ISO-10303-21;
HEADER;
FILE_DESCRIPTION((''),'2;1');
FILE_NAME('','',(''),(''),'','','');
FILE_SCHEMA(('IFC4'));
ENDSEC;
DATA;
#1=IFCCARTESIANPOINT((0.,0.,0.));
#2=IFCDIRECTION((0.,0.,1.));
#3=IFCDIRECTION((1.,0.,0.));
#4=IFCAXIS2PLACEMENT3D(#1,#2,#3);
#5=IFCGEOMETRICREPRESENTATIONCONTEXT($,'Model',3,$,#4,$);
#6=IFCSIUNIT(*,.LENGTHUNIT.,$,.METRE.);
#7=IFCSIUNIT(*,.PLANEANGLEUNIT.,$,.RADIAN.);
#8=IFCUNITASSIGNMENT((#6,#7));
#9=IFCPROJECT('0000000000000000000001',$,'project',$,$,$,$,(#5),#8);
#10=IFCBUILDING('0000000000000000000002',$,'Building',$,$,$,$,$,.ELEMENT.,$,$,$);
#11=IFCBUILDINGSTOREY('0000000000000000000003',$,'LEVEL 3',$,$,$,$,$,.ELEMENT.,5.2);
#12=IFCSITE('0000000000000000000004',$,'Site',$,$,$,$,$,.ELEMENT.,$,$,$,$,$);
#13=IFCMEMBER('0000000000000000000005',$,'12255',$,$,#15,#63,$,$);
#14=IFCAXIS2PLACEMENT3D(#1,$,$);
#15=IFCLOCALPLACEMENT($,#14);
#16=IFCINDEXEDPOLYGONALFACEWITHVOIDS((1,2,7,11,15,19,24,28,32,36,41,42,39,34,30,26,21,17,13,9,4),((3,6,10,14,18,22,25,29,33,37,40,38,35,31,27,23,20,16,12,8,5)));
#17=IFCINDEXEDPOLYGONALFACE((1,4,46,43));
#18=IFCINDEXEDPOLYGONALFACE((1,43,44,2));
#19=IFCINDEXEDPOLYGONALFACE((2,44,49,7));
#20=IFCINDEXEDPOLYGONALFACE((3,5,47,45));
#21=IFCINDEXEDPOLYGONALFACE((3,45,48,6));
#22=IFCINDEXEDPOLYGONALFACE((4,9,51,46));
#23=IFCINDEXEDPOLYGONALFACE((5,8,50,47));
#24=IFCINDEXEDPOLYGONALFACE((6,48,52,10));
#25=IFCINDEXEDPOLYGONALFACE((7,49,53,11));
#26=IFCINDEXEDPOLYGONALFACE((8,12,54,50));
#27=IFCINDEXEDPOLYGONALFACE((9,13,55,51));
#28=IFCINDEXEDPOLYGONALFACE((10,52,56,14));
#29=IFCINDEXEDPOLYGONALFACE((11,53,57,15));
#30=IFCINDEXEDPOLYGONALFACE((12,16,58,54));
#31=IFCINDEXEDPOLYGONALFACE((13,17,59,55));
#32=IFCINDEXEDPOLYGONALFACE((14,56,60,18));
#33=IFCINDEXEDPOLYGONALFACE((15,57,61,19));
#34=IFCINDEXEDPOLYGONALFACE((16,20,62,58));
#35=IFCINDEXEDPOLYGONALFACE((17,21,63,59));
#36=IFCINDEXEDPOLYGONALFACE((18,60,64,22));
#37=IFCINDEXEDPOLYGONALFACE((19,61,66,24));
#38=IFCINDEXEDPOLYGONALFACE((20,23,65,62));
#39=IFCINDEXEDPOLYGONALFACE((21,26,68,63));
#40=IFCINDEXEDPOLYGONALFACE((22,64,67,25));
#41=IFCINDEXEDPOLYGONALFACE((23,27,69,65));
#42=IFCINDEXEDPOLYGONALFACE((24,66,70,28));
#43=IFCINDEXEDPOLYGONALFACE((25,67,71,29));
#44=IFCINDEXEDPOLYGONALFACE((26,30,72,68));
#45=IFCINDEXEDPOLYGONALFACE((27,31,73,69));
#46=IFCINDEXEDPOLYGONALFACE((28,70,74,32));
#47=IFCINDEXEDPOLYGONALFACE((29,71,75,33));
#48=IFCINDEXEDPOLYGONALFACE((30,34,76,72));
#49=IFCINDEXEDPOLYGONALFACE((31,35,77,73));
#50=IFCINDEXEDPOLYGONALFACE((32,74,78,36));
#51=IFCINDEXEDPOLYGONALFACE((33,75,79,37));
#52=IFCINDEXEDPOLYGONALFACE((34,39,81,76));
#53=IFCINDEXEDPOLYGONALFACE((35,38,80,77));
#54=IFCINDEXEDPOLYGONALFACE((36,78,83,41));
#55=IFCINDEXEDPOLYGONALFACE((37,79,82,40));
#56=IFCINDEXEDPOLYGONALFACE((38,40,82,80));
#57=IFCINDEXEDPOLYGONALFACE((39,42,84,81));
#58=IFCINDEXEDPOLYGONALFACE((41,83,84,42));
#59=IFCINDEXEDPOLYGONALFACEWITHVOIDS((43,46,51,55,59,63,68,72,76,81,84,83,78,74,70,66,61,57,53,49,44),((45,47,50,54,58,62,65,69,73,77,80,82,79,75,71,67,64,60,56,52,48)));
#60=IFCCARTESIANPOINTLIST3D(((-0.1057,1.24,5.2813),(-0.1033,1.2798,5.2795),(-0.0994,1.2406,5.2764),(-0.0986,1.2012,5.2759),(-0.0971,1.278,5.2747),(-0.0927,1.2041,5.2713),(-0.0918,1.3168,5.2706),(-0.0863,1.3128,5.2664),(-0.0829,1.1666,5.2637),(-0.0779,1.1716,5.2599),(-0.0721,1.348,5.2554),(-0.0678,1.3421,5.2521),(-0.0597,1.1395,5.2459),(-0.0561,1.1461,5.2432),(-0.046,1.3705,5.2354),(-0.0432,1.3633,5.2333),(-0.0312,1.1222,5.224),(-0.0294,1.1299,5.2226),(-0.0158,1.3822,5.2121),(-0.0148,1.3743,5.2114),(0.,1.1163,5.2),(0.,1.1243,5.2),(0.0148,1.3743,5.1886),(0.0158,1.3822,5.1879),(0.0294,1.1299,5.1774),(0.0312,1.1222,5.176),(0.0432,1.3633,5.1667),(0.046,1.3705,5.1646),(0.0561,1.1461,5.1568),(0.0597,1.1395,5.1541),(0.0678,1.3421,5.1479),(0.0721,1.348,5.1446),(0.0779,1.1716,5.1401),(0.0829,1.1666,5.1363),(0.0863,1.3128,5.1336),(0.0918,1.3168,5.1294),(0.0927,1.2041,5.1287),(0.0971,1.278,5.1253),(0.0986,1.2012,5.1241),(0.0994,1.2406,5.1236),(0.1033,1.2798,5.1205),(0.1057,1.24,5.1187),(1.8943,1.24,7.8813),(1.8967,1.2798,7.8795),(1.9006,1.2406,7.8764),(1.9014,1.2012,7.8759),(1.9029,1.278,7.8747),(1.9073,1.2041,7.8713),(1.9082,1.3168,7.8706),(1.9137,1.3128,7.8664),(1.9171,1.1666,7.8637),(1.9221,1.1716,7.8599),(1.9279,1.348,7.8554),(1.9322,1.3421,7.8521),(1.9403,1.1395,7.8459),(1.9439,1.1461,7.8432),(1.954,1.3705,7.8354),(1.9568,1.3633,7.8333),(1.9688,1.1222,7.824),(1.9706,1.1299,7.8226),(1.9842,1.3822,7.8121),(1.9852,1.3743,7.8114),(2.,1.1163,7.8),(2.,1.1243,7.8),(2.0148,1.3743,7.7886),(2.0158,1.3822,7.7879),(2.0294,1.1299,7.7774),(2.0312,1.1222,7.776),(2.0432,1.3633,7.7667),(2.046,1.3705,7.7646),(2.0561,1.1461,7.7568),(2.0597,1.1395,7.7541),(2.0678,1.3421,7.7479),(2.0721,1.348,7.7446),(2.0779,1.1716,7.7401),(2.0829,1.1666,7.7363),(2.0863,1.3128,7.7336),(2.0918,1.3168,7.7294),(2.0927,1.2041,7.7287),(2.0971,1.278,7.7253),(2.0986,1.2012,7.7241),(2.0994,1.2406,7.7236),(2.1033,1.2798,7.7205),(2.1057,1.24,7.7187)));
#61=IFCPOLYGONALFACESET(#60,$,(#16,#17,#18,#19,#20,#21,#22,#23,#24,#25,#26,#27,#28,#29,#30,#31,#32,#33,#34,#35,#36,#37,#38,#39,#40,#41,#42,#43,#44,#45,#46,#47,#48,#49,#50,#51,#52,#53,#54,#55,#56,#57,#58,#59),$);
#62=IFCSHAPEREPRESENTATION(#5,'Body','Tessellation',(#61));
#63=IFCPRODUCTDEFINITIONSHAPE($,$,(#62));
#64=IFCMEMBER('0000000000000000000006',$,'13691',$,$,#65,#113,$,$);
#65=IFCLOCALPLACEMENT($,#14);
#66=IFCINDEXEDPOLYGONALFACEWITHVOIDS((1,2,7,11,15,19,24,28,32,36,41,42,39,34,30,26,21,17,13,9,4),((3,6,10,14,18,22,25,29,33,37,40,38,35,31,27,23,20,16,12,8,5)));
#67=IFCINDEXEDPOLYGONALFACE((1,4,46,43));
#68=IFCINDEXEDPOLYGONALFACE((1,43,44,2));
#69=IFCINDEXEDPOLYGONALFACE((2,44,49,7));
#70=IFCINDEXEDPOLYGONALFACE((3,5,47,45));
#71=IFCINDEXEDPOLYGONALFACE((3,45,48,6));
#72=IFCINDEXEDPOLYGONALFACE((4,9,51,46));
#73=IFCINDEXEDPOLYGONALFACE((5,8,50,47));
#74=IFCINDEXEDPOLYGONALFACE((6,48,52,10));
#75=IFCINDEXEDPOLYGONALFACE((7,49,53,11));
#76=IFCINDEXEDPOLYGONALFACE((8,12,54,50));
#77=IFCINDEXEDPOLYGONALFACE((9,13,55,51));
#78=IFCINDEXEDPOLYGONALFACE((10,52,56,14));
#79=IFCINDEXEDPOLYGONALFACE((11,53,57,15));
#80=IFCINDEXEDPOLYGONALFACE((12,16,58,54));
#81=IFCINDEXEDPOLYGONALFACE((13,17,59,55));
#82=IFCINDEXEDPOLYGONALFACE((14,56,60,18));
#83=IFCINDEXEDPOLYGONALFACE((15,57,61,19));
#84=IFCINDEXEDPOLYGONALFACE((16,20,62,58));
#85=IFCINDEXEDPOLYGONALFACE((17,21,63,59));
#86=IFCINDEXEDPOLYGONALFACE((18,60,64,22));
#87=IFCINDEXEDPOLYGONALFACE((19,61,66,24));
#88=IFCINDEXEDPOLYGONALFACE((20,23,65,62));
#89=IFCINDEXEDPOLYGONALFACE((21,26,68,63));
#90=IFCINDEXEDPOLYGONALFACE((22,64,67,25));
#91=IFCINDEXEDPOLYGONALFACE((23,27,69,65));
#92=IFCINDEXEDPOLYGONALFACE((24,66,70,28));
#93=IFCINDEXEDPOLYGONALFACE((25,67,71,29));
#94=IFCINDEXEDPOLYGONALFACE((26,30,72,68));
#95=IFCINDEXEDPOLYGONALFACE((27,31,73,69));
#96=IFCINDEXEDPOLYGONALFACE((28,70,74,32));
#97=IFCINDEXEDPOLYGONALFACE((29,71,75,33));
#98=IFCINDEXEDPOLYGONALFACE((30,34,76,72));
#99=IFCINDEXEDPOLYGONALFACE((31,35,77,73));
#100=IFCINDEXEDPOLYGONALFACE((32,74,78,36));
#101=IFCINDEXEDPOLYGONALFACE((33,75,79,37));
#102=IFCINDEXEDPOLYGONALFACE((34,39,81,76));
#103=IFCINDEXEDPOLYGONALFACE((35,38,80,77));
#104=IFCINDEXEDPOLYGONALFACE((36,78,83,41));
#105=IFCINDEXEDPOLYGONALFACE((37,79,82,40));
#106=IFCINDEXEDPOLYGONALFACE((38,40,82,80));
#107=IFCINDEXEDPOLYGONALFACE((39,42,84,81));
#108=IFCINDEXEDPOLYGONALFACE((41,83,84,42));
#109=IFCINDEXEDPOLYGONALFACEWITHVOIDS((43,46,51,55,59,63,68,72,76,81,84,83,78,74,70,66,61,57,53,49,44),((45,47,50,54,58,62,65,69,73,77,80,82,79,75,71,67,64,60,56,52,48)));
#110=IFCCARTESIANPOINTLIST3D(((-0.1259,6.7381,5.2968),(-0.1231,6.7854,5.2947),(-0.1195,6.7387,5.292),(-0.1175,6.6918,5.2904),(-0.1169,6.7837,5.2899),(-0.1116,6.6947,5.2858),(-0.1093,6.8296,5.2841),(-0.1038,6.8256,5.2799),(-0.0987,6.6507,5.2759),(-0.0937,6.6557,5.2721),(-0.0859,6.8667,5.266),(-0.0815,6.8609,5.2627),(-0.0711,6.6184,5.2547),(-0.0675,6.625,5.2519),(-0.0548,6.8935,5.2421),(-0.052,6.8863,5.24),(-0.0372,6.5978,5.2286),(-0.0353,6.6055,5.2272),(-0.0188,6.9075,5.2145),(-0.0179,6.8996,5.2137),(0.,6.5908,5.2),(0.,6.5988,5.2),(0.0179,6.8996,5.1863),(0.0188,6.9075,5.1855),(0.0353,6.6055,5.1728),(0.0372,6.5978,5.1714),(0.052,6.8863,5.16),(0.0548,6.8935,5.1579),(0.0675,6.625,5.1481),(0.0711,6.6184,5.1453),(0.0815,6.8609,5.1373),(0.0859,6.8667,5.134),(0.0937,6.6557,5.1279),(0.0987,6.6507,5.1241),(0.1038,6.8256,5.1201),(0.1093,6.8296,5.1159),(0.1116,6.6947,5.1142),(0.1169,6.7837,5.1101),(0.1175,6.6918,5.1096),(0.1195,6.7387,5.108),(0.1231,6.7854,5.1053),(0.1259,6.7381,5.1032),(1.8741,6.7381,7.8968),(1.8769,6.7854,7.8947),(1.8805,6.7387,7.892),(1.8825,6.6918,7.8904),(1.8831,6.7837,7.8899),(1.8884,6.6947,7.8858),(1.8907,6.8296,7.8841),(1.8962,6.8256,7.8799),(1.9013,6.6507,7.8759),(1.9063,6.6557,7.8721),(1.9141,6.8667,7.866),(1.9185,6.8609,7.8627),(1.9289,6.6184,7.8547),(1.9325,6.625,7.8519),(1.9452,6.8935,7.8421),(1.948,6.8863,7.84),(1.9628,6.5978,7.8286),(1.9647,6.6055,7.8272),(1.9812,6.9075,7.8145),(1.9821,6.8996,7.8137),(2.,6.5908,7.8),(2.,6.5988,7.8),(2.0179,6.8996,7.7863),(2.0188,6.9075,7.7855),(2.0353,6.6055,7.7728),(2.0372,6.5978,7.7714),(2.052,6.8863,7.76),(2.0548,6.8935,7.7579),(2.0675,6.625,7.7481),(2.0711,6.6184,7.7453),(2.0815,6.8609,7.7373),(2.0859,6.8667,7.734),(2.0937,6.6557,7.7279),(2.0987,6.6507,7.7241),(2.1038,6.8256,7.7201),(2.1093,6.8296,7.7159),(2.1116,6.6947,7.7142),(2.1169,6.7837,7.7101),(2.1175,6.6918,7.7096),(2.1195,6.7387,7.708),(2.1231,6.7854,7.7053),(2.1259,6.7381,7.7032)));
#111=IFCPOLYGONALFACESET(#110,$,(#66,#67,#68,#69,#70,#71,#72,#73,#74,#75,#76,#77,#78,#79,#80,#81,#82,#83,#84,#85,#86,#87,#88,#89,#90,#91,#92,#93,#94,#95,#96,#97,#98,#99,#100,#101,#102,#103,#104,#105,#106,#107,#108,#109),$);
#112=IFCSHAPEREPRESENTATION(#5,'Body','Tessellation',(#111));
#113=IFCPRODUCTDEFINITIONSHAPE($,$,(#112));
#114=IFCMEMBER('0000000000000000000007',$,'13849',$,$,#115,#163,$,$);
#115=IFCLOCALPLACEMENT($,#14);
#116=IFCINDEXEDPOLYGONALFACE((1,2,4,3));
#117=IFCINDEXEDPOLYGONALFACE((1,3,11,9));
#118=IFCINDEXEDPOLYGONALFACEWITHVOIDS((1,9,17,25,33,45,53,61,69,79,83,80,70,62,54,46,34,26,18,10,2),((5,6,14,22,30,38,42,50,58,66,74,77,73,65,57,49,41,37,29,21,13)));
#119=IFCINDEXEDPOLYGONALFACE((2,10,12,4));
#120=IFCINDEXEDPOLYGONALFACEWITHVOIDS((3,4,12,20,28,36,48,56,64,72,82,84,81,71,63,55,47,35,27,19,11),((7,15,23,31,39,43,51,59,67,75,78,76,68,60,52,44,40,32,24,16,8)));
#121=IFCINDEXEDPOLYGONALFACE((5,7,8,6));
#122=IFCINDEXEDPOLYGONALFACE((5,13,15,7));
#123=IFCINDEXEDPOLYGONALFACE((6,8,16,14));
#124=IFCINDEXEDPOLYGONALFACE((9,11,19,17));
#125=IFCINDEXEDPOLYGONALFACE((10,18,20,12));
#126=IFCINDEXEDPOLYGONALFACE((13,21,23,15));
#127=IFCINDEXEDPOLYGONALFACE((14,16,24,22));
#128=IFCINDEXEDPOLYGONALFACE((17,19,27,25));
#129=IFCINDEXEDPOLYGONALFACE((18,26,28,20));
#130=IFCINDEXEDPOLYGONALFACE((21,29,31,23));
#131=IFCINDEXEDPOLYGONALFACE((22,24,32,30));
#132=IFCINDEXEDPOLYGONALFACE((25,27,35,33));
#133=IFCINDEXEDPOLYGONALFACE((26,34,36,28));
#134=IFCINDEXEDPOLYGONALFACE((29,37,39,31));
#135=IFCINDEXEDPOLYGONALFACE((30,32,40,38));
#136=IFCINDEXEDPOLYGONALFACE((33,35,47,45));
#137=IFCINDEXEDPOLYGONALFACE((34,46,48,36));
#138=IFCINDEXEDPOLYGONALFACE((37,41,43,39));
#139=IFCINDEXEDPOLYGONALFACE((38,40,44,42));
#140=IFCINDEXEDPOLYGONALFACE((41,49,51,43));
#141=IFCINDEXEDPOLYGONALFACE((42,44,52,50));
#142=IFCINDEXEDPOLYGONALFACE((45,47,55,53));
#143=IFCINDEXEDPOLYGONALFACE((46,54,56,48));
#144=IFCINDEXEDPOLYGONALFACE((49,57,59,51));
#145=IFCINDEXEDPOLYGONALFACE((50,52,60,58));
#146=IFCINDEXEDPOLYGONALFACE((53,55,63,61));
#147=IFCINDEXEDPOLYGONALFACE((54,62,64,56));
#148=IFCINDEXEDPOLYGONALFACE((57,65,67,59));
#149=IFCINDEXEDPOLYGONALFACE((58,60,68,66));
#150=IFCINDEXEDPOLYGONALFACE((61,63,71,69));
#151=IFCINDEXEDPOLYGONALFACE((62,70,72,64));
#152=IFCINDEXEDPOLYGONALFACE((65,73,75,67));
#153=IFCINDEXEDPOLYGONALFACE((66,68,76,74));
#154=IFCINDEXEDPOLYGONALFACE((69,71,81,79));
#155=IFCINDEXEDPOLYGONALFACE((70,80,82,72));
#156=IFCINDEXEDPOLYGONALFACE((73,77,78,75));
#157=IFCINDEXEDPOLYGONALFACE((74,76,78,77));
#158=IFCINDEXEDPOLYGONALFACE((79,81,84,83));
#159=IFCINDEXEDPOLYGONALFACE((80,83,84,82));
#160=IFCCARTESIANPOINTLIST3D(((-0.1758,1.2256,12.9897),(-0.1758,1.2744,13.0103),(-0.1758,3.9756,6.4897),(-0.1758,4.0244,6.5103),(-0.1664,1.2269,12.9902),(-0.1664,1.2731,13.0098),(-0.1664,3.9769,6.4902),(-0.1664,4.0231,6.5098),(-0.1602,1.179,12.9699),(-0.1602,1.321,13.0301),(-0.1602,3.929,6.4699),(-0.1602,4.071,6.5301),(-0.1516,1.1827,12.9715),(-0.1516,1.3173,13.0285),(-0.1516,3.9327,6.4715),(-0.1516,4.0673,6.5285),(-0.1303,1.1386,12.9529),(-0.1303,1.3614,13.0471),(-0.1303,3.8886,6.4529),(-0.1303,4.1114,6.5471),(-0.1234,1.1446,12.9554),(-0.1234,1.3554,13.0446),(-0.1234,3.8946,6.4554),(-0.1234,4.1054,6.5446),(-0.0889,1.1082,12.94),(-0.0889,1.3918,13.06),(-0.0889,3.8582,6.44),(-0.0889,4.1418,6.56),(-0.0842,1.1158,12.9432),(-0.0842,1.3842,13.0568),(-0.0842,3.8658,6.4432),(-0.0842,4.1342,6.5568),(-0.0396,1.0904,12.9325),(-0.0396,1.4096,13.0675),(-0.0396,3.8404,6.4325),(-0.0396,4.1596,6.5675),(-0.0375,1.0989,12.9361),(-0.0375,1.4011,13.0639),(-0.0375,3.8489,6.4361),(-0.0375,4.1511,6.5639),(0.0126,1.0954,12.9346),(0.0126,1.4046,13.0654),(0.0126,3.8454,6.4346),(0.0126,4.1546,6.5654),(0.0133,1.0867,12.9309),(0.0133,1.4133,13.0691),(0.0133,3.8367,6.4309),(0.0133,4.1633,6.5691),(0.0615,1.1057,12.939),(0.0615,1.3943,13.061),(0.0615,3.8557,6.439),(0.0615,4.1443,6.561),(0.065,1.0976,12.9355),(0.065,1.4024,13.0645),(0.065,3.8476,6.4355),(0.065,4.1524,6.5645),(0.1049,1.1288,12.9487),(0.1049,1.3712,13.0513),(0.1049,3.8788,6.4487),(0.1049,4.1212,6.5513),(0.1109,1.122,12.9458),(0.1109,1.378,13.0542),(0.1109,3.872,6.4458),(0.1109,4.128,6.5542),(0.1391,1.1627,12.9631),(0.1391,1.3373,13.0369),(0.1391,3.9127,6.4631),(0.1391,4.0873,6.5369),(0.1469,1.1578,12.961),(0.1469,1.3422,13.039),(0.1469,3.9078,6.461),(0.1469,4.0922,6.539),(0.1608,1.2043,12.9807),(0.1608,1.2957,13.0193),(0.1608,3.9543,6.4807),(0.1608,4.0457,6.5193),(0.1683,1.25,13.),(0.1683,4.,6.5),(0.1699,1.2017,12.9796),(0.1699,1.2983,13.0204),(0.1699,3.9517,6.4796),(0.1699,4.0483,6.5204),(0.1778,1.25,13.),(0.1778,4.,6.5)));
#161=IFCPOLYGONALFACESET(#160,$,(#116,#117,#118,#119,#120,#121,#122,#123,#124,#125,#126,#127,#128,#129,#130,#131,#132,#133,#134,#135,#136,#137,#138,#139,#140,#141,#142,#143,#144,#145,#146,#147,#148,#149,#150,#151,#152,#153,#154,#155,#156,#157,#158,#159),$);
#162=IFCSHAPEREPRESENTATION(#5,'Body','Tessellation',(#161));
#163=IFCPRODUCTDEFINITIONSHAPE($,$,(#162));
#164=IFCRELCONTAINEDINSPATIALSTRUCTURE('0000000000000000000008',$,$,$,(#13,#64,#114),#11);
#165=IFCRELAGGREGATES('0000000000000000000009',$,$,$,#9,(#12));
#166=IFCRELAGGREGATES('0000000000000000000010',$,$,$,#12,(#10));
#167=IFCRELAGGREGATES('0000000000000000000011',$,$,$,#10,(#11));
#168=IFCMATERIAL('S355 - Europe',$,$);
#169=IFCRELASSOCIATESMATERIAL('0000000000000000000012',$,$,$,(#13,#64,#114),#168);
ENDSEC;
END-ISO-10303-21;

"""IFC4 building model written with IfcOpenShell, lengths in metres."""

from ifc_helpers import new_model, si_unit, frame, origin_with_axes, origin_2d_with_axis, place, context, project, spatial, hollow_circle, extrude, material, material_profile, profile_set, profile_usage, element, save


model = new_model("IFC4")

# Units and contexts
model_context = context("Model", 3, world=origin_with_axes())
ifc_project = project(units=[si_unit("LENGTHUNIT", "METRE"), si_unit("PLANEANGLEUNIT", "RADIAN")], contexts=[model_context])

# Site, building, storey
site = spatial("IfcSite", under=ifc_project, Name="Site", CompositionType="ELEMENT")
building = spatial("IfcBuilding", under=site, Name="Building", CompositionType="ELEMENT")
storey = spatial("IfcBuildingStorey", under=building, Name="LEVEL 3", CompositionType="ELEMENT", Elevation=5.2)

# Shared definitions
ifc_material = material(Name="S355 - Europe")

# Members
ifc_material_profile_1 = material_profile(ifc_material, hollow_circle(Radius=0.1337, WallThickness=0.008, at=origin_2d_with_axis()))
ifc_profile_set_1 = profile_set([ifc_material_profile_1])
ifc_profile_usage_1 = profile_usage(ifc_profile_set_1, cardinal=10)
member_1_placement = place(None, frame((2.0, 1.25, 7.8), z_axis=(-0.609711, 0.0, -0.792624), x_axis=(0.0, -1.0, 0.0)))
element("IfcMember", 1, at=member_1_placement, inside=storey, material=ifc_profile_usage_1, Name="12255", context=model_context, shape_type="SweptSolid", body=[
    extrude(hollow_circle(Radius=0.1337, WallThickness=0.008, at=origin_2d_with_axis()), origin_with_axes(), (0.0, 0.0, 1.0), 3.2802),
])
ifc_material_profile_2 = material_profile(ifc_material, hollow_circle(Radius=0.1593, WallThickness=0.008, at=origin_2d_with_axis()))
ifc_profile_set_2 = profile_set([ifc_material_profile_2])
ifc_profile_usage_2 = profile_usage(ifc_profile_set_2, cardinal=10)
member_2_placement = place(None, frame((2.0, 6.75, 7.8), z_axis=(-0.609711, 0.0, -0.792624), x_axis=(0.0, -1.0, 0.0)))
element("IfcMember", 2, at=member_2_placement, inside=storey, material=ifc_profile_usage_2, Name="13691", context=model_context, shape_type="SweptSolid", body=[
    extrude(hollow_circle(Radius=0.1593, WallThickness=0.008, at=origin_2d_with_axis()), origin_with_axes(), (0.0, 0.0, 1.0), 3.2802),
])
ifc_material_profile_3 = material_profile(ifc_material, hollow_circle(Radius=0.1778, WallThickness=0.0095, at=origin_2d_with_axis()))
ifc_profile_set_3 = profile_set([ifc_material_profile_3])
ifc_profile_usage_3 = profile_usage(ifc_profile_set_3, cardinal=10)
member_3_placement = place(None, frame((0.0, 4.0, 6.5), z_axis=(0.0, -0.38964, 0.920967), x_axis=(1.0, 0.0, 0.0)))
element("IfcMember", 3, at=member_3_placement, inside=storey, material=ifc_profile_usage_3, Name="13849", context=model_context, shape_type="SweptSolid", body=[
    extrude(hollow_circle(Radius=0.1778, WallThickness=0.0095, at=origin_2d_with_axis()), origin_with_axes(), (0.0, 0.0, 1.0), 7.0578),
])

save(model, "model.ifc")
